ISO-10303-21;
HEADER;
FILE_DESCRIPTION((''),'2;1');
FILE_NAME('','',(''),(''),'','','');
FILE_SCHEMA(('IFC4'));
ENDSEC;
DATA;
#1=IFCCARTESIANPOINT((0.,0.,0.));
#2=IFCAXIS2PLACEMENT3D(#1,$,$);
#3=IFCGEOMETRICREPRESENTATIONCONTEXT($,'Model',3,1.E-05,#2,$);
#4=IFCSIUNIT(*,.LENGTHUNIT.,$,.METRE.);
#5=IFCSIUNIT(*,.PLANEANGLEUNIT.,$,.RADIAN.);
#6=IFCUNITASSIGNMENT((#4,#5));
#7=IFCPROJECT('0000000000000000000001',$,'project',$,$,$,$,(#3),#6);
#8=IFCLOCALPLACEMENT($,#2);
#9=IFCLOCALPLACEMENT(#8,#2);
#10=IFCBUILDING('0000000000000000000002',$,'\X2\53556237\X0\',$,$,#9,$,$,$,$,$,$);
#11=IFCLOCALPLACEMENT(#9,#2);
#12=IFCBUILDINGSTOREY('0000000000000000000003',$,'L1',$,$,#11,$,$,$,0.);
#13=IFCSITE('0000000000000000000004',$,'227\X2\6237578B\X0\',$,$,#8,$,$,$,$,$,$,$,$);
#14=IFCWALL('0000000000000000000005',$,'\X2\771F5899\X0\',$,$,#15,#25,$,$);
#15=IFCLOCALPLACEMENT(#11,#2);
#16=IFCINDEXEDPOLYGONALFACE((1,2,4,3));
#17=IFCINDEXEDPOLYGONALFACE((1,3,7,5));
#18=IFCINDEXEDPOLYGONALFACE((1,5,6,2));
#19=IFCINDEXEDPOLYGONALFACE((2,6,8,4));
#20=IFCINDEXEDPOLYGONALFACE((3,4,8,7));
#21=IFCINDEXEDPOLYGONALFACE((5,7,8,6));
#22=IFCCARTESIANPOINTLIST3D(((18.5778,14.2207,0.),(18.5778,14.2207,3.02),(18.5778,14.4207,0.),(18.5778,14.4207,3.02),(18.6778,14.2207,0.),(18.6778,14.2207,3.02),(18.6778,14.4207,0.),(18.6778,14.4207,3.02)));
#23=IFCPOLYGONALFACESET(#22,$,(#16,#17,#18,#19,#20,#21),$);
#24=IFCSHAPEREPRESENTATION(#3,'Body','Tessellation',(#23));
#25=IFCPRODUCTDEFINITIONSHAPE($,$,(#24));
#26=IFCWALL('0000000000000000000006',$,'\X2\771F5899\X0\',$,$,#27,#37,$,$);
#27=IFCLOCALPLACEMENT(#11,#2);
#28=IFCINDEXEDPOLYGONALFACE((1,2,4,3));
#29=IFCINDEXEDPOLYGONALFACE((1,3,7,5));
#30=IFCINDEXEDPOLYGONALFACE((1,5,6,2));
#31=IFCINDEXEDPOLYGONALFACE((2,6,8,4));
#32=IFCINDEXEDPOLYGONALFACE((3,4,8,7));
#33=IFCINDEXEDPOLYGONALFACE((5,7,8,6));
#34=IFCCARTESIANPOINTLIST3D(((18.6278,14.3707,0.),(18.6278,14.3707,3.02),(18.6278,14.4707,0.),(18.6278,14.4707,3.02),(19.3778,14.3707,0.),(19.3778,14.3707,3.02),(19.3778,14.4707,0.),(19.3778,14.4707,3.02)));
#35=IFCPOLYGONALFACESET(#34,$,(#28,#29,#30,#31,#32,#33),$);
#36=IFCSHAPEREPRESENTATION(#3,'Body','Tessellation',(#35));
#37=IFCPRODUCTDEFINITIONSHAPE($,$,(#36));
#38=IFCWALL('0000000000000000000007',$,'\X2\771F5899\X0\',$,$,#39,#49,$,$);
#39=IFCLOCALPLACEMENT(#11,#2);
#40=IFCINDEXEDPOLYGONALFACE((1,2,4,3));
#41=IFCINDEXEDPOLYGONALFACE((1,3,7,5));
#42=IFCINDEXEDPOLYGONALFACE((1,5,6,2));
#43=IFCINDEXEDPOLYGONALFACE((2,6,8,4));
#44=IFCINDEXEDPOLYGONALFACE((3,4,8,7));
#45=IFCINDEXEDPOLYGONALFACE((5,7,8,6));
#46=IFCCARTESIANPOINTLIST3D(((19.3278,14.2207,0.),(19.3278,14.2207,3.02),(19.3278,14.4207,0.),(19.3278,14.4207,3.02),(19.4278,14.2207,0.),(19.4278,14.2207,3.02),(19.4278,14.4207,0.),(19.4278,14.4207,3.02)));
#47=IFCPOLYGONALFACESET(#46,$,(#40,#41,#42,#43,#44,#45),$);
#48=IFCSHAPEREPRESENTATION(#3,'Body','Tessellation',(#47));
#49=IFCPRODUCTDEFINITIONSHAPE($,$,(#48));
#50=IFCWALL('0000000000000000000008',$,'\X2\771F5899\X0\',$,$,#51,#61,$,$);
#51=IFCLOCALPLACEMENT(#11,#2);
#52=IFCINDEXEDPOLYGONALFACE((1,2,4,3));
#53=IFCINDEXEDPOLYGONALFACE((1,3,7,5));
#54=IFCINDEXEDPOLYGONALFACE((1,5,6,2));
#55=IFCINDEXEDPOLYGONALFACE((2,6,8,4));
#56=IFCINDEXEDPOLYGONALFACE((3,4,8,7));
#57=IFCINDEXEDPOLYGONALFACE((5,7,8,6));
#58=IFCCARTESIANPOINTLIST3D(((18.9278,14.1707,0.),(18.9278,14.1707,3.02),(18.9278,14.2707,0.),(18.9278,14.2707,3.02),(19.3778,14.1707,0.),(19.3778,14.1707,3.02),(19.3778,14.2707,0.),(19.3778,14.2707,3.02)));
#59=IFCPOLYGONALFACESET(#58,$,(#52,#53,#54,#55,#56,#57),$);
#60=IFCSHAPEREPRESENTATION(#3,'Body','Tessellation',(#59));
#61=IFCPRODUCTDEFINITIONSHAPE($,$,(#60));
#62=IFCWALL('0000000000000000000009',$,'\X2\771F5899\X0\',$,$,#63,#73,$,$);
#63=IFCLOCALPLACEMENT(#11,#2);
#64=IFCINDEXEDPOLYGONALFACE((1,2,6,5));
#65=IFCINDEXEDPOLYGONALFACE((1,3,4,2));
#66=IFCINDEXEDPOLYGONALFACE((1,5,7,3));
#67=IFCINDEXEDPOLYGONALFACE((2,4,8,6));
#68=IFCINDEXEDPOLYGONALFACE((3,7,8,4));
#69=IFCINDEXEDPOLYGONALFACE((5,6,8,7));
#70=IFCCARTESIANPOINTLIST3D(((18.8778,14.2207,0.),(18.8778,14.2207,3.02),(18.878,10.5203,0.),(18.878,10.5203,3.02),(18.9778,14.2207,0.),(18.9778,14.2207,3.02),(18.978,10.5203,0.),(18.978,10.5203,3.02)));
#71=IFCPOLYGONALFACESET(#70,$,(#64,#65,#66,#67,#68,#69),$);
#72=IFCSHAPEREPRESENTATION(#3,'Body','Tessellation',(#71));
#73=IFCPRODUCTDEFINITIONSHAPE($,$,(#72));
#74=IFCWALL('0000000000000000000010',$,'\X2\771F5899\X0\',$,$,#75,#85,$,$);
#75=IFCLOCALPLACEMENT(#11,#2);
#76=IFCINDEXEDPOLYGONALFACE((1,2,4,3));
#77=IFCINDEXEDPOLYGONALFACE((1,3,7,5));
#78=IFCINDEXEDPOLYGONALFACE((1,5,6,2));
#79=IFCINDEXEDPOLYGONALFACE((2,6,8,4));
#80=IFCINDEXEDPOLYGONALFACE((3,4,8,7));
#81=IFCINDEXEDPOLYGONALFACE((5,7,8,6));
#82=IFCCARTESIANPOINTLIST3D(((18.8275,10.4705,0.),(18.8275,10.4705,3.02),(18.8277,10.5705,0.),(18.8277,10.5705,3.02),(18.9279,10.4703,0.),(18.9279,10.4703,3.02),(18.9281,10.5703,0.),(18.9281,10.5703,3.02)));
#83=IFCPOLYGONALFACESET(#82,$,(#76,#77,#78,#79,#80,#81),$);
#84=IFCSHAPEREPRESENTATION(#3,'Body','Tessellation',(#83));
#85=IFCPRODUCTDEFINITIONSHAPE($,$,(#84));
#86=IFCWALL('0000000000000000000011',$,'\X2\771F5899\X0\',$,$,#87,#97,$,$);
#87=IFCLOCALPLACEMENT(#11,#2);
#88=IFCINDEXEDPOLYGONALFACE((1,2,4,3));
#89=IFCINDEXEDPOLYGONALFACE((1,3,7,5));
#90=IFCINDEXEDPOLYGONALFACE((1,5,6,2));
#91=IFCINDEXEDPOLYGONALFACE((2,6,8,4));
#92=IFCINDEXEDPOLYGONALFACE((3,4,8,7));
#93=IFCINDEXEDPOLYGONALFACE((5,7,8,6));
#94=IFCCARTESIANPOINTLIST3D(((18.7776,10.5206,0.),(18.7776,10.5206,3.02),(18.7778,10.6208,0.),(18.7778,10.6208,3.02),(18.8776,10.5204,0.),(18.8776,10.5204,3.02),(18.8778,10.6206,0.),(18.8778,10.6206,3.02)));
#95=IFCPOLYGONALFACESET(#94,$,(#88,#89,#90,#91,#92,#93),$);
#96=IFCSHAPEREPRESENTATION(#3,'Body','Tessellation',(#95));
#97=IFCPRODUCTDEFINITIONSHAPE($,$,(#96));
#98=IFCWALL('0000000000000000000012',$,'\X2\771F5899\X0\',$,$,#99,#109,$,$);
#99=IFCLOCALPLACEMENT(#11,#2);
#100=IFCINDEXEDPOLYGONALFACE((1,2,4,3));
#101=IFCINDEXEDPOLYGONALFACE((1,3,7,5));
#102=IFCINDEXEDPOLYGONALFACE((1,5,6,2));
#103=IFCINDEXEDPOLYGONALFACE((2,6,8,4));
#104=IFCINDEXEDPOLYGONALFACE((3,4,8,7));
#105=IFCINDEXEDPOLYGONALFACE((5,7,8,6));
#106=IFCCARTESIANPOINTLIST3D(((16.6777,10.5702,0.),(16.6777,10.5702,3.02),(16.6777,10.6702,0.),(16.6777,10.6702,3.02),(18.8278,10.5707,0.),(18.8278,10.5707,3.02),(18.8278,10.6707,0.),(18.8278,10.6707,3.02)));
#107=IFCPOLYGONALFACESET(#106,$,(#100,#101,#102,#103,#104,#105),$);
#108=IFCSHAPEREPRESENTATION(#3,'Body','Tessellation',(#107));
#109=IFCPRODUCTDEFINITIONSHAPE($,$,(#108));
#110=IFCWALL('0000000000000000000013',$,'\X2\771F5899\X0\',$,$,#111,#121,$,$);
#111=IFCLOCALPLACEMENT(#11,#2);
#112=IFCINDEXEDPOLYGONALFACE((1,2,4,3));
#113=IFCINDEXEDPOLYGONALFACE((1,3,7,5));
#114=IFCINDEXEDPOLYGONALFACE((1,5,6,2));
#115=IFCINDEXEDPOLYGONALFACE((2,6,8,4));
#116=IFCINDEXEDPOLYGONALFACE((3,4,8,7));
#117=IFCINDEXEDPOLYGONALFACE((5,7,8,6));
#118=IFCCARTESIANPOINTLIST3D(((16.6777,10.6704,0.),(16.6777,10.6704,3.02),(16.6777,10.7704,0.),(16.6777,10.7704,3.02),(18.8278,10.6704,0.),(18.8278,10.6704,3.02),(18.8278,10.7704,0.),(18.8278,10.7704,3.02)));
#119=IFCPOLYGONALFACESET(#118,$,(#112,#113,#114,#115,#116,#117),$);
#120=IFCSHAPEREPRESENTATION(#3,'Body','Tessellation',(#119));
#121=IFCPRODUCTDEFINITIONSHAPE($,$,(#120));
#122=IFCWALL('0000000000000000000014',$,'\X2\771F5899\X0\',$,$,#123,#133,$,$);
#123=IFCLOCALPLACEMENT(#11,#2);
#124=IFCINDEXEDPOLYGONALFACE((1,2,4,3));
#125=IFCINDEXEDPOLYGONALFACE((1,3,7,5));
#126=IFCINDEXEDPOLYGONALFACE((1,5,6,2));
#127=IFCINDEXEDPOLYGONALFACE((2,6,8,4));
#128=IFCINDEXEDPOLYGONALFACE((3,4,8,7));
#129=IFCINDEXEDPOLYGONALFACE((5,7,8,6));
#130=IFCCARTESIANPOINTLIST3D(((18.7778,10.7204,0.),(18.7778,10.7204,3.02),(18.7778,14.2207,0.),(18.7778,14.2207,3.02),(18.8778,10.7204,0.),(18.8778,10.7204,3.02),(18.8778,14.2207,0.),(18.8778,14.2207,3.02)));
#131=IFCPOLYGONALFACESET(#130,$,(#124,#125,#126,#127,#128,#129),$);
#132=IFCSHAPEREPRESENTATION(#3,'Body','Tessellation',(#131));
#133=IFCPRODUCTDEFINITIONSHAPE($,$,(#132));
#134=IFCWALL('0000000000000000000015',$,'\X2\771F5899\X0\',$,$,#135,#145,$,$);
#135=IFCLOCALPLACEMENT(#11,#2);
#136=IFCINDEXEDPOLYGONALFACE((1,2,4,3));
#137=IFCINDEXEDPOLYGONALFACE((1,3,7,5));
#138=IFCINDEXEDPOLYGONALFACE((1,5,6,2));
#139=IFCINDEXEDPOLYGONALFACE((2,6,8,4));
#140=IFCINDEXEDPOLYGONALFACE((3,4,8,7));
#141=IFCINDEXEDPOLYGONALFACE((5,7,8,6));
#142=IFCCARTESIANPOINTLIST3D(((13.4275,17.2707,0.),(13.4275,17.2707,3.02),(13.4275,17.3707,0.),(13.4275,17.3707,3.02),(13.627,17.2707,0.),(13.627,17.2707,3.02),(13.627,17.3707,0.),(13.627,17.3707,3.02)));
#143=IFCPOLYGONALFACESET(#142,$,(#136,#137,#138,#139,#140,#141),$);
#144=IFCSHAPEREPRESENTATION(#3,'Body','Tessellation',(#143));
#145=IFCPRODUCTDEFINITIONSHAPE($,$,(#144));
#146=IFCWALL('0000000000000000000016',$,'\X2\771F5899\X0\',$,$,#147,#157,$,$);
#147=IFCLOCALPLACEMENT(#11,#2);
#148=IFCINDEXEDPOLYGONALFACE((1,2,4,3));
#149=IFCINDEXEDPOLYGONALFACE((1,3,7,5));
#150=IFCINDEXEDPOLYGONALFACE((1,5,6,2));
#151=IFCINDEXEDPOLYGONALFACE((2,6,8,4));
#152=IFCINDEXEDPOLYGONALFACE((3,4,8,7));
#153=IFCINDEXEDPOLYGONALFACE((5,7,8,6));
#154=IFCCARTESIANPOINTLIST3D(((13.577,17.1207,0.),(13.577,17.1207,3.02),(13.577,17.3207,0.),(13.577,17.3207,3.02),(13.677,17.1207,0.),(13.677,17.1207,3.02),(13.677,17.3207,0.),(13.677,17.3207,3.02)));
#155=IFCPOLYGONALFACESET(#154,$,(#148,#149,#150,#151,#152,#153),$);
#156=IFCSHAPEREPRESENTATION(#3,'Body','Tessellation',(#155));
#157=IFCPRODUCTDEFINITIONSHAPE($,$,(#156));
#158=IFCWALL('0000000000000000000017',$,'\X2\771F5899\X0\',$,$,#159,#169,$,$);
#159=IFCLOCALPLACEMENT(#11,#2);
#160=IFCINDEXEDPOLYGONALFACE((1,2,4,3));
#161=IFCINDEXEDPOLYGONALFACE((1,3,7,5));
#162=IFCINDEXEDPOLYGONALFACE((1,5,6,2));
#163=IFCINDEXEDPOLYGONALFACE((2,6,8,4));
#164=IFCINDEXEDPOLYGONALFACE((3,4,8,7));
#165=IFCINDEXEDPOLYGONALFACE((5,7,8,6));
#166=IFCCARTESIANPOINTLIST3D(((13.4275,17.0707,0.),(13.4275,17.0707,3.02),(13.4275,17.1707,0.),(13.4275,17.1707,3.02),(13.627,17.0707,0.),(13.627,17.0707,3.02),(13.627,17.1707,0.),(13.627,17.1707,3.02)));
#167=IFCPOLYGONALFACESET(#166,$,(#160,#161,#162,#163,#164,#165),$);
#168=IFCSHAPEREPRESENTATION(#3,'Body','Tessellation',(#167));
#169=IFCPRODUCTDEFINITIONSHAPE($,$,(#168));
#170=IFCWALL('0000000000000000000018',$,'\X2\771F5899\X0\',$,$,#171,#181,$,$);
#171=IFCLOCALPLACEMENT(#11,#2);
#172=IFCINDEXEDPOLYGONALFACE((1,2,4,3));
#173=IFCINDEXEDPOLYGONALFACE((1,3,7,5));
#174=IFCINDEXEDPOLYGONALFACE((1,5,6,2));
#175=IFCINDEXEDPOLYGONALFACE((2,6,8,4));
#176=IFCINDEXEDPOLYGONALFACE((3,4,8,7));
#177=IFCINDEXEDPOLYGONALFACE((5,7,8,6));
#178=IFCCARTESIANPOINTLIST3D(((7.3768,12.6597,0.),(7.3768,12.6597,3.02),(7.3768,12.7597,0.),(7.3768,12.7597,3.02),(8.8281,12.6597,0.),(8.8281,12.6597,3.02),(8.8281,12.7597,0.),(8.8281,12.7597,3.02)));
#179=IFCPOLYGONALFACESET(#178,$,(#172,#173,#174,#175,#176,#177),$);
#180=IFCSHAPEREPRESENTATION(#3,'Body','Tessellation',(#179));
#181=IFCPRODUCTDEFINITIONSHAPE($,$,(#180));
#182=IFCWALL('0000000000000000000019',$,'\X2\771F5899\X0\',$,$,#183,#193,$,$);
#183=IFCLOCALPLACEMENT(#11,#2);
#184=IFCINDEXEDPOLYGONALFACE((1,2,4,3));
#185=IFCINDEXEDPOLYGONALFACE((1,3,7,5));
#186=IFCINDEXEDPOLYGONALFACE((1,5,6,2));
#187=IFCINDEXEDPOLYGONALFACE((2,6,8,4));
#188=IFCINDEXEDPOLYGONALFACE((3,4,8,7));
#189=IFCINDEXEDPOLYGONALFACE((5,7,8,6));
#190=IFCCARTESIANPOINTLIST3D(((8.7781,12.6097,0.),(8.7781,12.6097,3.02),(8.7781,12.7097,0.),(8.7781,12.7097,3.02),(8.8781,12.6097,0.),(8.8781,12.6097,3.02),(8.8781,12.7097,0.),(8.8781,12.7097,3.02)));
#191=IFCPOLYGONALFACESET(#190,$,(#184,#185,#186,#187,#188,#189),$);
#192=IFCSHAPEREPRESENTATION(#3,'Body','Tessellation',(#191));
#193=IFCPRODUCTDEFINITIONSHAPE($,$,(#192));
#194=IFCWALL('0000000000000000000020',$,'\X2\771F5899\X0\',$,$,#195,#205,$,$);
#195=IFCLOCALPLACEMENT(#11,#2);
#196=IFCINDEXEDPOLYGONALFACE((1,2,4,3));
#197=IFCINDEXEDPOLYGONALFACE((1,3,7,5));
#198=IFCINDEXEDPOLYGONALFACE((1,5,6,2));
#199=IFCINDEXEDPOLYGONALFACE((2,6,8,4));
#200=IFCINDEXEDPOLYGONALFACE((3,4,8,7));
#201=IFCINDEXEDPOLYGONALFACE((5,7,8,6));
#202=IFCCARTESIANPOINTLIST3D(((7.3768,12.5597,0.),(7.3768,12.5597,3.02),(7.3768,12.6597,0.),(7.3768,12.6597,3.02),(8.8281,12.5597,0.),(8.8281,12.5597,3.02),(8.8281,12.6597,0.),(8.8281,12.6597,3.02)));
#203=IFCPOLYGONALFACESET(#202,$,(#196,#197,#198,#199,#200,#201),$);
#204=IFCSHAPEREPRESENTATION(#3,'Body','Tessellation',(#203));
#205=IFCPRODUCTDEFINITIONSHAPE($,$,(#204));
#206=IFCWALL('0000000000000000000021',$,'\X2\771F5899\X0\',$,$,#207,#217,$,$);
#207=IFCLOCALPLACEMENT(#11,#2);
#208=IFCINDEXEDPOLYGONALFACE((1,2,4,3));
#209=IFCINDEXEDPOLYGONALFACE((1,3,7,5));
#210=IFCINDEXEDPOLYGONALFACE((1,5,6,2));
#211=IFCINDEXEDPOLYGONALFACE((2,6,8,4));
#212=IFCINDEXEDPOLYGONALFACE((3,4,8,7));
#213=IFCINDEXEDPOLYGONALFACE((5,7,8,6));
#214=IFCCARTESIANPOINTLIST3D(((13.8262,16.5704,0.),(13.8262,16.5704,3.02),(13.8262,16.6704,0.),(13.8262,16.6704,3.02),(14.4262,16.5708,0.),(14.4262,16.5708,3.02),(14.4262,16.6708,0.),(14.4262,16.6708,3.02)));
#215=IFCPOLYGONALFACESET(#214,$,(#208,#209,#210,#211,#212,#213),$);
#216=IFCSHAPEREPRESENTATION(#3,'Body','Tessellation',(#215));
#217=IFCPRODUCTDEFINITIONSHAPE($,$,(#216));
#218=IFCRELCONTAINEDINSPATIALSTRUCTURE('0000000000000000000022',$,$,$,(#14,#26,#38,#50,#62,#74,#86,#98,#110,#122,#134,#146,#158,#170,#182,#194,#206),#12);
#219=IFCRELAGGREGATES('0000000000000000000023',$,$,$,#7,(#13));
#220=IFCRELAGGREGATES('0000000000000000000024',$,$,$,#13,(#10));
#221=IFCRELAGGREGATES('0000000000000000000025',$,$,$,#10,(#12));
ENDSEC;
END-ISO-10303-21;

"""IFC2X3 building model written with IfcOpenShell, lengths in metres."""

from ifc_helpers import new_model, si_unit, origin, place, context, project, spatial, polyline, outline, extrude, element, save


model = new_model("IFC2X3")

# Units and contexts
model_context = context("Model", 3, precision=1e-05, world=origin())
ifc_project = project(units=[si_unit("LENGTHUNIT", "METRE"), si_unit("PLANEANGLEUNIT", "RADIAN")], contexts=[model_context])

# Site, building, storey
site_placement = place(None, origin())
site = spatial("IfcSite", under=ifc_project, at=site_placement, Name="227户型")
building_placement = place(site_placement, origin())
building = spatial("IfcBuilding", under=site, at=building_placement, Name="单户")
storey_placement = place(building_placement, origin())
storey = spatial("IfcBuildingStorey", under=building, at=storey_placement, Name="L1", Elevation=0.0)

# Walls
wall_1_placement = place(storey_placement, origin())
element("IfcWall", 1, at=wall_1_placement, inside=storey, Name="真墙", context=model_context, shape_type="SweptSolid", body=[
    extrude(outline(polyline([(18.5778, 14.2207), (18.5778, 14.4207), (18.6778, 14.4207), (18.6778, 14.2207), (18.5778, 14.2207)])), origin(), (0.0, 0.0, 1.0), 3.02),
])
wall_2_placement = place(storey_placement, origin())
element("IfcWall", 2, at=wall_2_placement, inside=storey, Name="真墙", context=model_context, shape_type="SweptSolid", body=[
    extrude(outline(polyline([(18.6278, 14.4707), (19.3778, 14.4707), (19.3778, 14.3707), (18.6278, 14.3707), (18.6278, 14.4707)])), origin(), (0.0, 0.0, 1.0), 3.02),
])
wall_3_placement = place(storey_placement, origin())
element("IfcWall", 3, at=wall_3_placement, inside=storey, Name="真墙", context=model_context, shape_type="SweptSolid", body=[
    extrude(outline(polyline([(19.4278, 14.4207), (19.4278, 14.2207), (19.3278, 14.2207), (19.3278, 14.4207), (19.4278, 14.4207)])), origin(), (0.0, 0.0, 1.0), 3.02),
])
wall_4_placement = place(storey_placement, origin())
element("IfcWall", 4, at=wall_4_placement, inside=storey, Name="真墙", context=model_context, shape_type="SweptSolid", body=[
    extrude(outline(polyline([(19.3778, 14.1707), (18.9278, 14.1707), (18.9278, 14.2707), (19.3778, 14.2707), (19.3778, 14.1707)])), origin(), (0.0, 0.0, 1.0), 3.02),
])
wall_5_placement = place(storey_placement, origin())
element("IfcWall", 5, at=wall_5_placement, inside=storey, Name="真墙", context=model_context, shape_type="SweptSolid", body=[
    extrude(outline(polyline([(18.9778, 14.2207), (18.978, 10.5203), (18.878, 10.5203), (18.8778, 14.2207), (18.9778, 14.2207)])), origin(), (0.0, 0.0, 1.0), 3.02),
])
wall_6_placement = place(storey_placement, origin())
element("IfcWall", 6, at=wall_6_placement, inside=storey, Name="真墙", context=model_context, shape_type="SweptSolid", body=[
    extrude(outline(polyline([(18.9279, 10.4703), (18.8275, 10.4705), (18.8277, 10.5705), (18.9281, 10.5703), (18.9279, 10.4703)])), origin(), (0.0, 0.0, 1.0), 3.02),
])
wall_7_placement = place(storey_placement, origin())
element("IfcWall", 7, at=wall_7_placement, inside=storey, Name="真墙", context=model_context, shape_type="SweptSolid", body=[
    extrude(outline(polyline([(18.7776, 10.5206), (18.7778, 10.6208), (18.8778, 10.6206), (18.8776, 10.5204), (18.7776, 10.5206)])), origin(), (0.0, 0.0, 1.0), 3.02),
])
wall_8_placement = place(storey_placement, origin())
element("IfcWall", 8, at=wall_8_placement, inside=storey, Name="真墙", context=model_context, shape_type="SweptSolid", body=[
    extrude(outline(polyline([(18.8278, 10.5707), (16.6777, 10.5702), (16.6777, 10.6702), (18.8278, 10.6707), (18.8278, 10.5707)])), origin(), (0.0, 0.0, 1.0), 3.02),
])

# Walls
wall_9_placement = place(storey_placement, origin())
element("IfcWall", 9, at=wall_9_placement, inside=storey, Name="真墙", context=model_context, shape_type="SweptSolid", body=[
    extrude(outline(polyline([(16.6777, 10.7704), (18.8278, 10.7704), (18.8278, 10.6704), (16.6777, 10.6704), (16.6777, 10.7704)])), origin(), (0.0, 0.0, 1.0), 3.02),
])
wall_10_placement = place(storey_placement, origin())
element("IfcWall", 10, at=wall_10_placement, inside=storey, Name="真墙", context=model_context, shape_type="SweptSolid", body=[
    extrude(outline(polyline([(18.7778, 10.7204), (18.7778, 14.2207), (18.8778, 14.2207), (18.8778, 10.7204), (18.7778, 10.7204)])), origin(), (0.0, 0.0, 1.0), 3.02),
])
wall_11_placement = place(storey_placement, origin())
element("IfcWall", 11, at=wall_11_placement, inside=storey, Name="真墙", context=model_context, shape_type="SweptSolid", body=[
    extrude(outline(polyline([(13.4275, 17.3707), (13.627, 17.3707), (13.627, 17.2707), (13.4275, 17.2707), (13.4275, 17.3707)])), origin(), (0.0, 0.0, 1.0), 3.02),
])
wall_12_placement = place(storey_placement, origin())
element("IfcWall", 12, at=wall_12_placement, inside=storey, Name="真墙", context=model_context, shape_type="SweptSolid", body=[
    extrude(outline(polyline([(13.677, 17.3207), (13.677, 17.1207), (13.577, 17.1207), (13.577, 17.3207), (13.677, 17.3207)])), origin(), (0.0, 0.0, 1.0), 3.02),
])
wall_13_placement = place(storey_placement, origin())
element("IfcWall", 13, at=wall_13_placement, inside=storey, Name="真墙", context=model_context, shape_type="SweptSolid", body=[
    extrude(outline(polyline([(13.627, 17.0707), (13.4275, 17.0707), (13.4275, 17.1707), (13.627, 17.1707), (13.627, 17.0707)])), origin(), (0.0, 0.0, 1.0), 3.02),
])
wall_14_placement = place(storey_placement, origin())
element("IfcWall", 14, at=wall_14_placement, inside=storey, Name="真墙", context=model_context, shape_type="SweptSolid", body=[
    extrude(outline(polyline([(7.3768, 12.7597), (8.8281, 12.7597), (8.8281, 12.6597), (7.3768, 12.6597), (7.3768, 12.7597)])), origin(), (0.0, 0.0, 1.0), 3.02),
])
wall_15_placement = place(storey_placement, origin())
element("IfcWall", 15, at=wall_15_placement, inside=storey, Name="真墙", context=model_context, shape_type="SweptSolid", body=[
    extrude(outline(polyline([(8.8781, 12.7097), (8.8781, 12.6097), (8.7781, 12.6097), (8.7781, 12.7097), (8.8781, 12.7097)])), origin(), (0.0, 0.0, 1.0), 3.02),
])
wall_16_placement = place(storey_placement, origin())
element("IfcWall", 16, at=wall_16_placement, inside=storey, Name="真墙", context=model_context, shape_type="SweptSolid", body=[
    extrude(outline(polyline([(8.8281, 12.5597), (7.3768, 12.5597), (7.3768, 12.6597), (8.8281, 12.6597), (8.8281, 12.5597)])), origin(), (0.0, 0.0, 1.0), 3.02),
])
wall_17_placement = place(storey_placement, origin())
element("IfcWall", 17, at=wall_17_placement, inside=storey, Name="真墙", context=model_context, shape_type="SweptSolid", body=[
    extrude(outline(polyline([(14.4262, 16.5708), (13.8262, 16.5704), (13.8262, 16.6704), (14.4262, 16.6708), (14.4262, 16.5708)])), origin(), (0.0, 0.0, 1.0), 3.02),
])

save(model, "model.ifc")
